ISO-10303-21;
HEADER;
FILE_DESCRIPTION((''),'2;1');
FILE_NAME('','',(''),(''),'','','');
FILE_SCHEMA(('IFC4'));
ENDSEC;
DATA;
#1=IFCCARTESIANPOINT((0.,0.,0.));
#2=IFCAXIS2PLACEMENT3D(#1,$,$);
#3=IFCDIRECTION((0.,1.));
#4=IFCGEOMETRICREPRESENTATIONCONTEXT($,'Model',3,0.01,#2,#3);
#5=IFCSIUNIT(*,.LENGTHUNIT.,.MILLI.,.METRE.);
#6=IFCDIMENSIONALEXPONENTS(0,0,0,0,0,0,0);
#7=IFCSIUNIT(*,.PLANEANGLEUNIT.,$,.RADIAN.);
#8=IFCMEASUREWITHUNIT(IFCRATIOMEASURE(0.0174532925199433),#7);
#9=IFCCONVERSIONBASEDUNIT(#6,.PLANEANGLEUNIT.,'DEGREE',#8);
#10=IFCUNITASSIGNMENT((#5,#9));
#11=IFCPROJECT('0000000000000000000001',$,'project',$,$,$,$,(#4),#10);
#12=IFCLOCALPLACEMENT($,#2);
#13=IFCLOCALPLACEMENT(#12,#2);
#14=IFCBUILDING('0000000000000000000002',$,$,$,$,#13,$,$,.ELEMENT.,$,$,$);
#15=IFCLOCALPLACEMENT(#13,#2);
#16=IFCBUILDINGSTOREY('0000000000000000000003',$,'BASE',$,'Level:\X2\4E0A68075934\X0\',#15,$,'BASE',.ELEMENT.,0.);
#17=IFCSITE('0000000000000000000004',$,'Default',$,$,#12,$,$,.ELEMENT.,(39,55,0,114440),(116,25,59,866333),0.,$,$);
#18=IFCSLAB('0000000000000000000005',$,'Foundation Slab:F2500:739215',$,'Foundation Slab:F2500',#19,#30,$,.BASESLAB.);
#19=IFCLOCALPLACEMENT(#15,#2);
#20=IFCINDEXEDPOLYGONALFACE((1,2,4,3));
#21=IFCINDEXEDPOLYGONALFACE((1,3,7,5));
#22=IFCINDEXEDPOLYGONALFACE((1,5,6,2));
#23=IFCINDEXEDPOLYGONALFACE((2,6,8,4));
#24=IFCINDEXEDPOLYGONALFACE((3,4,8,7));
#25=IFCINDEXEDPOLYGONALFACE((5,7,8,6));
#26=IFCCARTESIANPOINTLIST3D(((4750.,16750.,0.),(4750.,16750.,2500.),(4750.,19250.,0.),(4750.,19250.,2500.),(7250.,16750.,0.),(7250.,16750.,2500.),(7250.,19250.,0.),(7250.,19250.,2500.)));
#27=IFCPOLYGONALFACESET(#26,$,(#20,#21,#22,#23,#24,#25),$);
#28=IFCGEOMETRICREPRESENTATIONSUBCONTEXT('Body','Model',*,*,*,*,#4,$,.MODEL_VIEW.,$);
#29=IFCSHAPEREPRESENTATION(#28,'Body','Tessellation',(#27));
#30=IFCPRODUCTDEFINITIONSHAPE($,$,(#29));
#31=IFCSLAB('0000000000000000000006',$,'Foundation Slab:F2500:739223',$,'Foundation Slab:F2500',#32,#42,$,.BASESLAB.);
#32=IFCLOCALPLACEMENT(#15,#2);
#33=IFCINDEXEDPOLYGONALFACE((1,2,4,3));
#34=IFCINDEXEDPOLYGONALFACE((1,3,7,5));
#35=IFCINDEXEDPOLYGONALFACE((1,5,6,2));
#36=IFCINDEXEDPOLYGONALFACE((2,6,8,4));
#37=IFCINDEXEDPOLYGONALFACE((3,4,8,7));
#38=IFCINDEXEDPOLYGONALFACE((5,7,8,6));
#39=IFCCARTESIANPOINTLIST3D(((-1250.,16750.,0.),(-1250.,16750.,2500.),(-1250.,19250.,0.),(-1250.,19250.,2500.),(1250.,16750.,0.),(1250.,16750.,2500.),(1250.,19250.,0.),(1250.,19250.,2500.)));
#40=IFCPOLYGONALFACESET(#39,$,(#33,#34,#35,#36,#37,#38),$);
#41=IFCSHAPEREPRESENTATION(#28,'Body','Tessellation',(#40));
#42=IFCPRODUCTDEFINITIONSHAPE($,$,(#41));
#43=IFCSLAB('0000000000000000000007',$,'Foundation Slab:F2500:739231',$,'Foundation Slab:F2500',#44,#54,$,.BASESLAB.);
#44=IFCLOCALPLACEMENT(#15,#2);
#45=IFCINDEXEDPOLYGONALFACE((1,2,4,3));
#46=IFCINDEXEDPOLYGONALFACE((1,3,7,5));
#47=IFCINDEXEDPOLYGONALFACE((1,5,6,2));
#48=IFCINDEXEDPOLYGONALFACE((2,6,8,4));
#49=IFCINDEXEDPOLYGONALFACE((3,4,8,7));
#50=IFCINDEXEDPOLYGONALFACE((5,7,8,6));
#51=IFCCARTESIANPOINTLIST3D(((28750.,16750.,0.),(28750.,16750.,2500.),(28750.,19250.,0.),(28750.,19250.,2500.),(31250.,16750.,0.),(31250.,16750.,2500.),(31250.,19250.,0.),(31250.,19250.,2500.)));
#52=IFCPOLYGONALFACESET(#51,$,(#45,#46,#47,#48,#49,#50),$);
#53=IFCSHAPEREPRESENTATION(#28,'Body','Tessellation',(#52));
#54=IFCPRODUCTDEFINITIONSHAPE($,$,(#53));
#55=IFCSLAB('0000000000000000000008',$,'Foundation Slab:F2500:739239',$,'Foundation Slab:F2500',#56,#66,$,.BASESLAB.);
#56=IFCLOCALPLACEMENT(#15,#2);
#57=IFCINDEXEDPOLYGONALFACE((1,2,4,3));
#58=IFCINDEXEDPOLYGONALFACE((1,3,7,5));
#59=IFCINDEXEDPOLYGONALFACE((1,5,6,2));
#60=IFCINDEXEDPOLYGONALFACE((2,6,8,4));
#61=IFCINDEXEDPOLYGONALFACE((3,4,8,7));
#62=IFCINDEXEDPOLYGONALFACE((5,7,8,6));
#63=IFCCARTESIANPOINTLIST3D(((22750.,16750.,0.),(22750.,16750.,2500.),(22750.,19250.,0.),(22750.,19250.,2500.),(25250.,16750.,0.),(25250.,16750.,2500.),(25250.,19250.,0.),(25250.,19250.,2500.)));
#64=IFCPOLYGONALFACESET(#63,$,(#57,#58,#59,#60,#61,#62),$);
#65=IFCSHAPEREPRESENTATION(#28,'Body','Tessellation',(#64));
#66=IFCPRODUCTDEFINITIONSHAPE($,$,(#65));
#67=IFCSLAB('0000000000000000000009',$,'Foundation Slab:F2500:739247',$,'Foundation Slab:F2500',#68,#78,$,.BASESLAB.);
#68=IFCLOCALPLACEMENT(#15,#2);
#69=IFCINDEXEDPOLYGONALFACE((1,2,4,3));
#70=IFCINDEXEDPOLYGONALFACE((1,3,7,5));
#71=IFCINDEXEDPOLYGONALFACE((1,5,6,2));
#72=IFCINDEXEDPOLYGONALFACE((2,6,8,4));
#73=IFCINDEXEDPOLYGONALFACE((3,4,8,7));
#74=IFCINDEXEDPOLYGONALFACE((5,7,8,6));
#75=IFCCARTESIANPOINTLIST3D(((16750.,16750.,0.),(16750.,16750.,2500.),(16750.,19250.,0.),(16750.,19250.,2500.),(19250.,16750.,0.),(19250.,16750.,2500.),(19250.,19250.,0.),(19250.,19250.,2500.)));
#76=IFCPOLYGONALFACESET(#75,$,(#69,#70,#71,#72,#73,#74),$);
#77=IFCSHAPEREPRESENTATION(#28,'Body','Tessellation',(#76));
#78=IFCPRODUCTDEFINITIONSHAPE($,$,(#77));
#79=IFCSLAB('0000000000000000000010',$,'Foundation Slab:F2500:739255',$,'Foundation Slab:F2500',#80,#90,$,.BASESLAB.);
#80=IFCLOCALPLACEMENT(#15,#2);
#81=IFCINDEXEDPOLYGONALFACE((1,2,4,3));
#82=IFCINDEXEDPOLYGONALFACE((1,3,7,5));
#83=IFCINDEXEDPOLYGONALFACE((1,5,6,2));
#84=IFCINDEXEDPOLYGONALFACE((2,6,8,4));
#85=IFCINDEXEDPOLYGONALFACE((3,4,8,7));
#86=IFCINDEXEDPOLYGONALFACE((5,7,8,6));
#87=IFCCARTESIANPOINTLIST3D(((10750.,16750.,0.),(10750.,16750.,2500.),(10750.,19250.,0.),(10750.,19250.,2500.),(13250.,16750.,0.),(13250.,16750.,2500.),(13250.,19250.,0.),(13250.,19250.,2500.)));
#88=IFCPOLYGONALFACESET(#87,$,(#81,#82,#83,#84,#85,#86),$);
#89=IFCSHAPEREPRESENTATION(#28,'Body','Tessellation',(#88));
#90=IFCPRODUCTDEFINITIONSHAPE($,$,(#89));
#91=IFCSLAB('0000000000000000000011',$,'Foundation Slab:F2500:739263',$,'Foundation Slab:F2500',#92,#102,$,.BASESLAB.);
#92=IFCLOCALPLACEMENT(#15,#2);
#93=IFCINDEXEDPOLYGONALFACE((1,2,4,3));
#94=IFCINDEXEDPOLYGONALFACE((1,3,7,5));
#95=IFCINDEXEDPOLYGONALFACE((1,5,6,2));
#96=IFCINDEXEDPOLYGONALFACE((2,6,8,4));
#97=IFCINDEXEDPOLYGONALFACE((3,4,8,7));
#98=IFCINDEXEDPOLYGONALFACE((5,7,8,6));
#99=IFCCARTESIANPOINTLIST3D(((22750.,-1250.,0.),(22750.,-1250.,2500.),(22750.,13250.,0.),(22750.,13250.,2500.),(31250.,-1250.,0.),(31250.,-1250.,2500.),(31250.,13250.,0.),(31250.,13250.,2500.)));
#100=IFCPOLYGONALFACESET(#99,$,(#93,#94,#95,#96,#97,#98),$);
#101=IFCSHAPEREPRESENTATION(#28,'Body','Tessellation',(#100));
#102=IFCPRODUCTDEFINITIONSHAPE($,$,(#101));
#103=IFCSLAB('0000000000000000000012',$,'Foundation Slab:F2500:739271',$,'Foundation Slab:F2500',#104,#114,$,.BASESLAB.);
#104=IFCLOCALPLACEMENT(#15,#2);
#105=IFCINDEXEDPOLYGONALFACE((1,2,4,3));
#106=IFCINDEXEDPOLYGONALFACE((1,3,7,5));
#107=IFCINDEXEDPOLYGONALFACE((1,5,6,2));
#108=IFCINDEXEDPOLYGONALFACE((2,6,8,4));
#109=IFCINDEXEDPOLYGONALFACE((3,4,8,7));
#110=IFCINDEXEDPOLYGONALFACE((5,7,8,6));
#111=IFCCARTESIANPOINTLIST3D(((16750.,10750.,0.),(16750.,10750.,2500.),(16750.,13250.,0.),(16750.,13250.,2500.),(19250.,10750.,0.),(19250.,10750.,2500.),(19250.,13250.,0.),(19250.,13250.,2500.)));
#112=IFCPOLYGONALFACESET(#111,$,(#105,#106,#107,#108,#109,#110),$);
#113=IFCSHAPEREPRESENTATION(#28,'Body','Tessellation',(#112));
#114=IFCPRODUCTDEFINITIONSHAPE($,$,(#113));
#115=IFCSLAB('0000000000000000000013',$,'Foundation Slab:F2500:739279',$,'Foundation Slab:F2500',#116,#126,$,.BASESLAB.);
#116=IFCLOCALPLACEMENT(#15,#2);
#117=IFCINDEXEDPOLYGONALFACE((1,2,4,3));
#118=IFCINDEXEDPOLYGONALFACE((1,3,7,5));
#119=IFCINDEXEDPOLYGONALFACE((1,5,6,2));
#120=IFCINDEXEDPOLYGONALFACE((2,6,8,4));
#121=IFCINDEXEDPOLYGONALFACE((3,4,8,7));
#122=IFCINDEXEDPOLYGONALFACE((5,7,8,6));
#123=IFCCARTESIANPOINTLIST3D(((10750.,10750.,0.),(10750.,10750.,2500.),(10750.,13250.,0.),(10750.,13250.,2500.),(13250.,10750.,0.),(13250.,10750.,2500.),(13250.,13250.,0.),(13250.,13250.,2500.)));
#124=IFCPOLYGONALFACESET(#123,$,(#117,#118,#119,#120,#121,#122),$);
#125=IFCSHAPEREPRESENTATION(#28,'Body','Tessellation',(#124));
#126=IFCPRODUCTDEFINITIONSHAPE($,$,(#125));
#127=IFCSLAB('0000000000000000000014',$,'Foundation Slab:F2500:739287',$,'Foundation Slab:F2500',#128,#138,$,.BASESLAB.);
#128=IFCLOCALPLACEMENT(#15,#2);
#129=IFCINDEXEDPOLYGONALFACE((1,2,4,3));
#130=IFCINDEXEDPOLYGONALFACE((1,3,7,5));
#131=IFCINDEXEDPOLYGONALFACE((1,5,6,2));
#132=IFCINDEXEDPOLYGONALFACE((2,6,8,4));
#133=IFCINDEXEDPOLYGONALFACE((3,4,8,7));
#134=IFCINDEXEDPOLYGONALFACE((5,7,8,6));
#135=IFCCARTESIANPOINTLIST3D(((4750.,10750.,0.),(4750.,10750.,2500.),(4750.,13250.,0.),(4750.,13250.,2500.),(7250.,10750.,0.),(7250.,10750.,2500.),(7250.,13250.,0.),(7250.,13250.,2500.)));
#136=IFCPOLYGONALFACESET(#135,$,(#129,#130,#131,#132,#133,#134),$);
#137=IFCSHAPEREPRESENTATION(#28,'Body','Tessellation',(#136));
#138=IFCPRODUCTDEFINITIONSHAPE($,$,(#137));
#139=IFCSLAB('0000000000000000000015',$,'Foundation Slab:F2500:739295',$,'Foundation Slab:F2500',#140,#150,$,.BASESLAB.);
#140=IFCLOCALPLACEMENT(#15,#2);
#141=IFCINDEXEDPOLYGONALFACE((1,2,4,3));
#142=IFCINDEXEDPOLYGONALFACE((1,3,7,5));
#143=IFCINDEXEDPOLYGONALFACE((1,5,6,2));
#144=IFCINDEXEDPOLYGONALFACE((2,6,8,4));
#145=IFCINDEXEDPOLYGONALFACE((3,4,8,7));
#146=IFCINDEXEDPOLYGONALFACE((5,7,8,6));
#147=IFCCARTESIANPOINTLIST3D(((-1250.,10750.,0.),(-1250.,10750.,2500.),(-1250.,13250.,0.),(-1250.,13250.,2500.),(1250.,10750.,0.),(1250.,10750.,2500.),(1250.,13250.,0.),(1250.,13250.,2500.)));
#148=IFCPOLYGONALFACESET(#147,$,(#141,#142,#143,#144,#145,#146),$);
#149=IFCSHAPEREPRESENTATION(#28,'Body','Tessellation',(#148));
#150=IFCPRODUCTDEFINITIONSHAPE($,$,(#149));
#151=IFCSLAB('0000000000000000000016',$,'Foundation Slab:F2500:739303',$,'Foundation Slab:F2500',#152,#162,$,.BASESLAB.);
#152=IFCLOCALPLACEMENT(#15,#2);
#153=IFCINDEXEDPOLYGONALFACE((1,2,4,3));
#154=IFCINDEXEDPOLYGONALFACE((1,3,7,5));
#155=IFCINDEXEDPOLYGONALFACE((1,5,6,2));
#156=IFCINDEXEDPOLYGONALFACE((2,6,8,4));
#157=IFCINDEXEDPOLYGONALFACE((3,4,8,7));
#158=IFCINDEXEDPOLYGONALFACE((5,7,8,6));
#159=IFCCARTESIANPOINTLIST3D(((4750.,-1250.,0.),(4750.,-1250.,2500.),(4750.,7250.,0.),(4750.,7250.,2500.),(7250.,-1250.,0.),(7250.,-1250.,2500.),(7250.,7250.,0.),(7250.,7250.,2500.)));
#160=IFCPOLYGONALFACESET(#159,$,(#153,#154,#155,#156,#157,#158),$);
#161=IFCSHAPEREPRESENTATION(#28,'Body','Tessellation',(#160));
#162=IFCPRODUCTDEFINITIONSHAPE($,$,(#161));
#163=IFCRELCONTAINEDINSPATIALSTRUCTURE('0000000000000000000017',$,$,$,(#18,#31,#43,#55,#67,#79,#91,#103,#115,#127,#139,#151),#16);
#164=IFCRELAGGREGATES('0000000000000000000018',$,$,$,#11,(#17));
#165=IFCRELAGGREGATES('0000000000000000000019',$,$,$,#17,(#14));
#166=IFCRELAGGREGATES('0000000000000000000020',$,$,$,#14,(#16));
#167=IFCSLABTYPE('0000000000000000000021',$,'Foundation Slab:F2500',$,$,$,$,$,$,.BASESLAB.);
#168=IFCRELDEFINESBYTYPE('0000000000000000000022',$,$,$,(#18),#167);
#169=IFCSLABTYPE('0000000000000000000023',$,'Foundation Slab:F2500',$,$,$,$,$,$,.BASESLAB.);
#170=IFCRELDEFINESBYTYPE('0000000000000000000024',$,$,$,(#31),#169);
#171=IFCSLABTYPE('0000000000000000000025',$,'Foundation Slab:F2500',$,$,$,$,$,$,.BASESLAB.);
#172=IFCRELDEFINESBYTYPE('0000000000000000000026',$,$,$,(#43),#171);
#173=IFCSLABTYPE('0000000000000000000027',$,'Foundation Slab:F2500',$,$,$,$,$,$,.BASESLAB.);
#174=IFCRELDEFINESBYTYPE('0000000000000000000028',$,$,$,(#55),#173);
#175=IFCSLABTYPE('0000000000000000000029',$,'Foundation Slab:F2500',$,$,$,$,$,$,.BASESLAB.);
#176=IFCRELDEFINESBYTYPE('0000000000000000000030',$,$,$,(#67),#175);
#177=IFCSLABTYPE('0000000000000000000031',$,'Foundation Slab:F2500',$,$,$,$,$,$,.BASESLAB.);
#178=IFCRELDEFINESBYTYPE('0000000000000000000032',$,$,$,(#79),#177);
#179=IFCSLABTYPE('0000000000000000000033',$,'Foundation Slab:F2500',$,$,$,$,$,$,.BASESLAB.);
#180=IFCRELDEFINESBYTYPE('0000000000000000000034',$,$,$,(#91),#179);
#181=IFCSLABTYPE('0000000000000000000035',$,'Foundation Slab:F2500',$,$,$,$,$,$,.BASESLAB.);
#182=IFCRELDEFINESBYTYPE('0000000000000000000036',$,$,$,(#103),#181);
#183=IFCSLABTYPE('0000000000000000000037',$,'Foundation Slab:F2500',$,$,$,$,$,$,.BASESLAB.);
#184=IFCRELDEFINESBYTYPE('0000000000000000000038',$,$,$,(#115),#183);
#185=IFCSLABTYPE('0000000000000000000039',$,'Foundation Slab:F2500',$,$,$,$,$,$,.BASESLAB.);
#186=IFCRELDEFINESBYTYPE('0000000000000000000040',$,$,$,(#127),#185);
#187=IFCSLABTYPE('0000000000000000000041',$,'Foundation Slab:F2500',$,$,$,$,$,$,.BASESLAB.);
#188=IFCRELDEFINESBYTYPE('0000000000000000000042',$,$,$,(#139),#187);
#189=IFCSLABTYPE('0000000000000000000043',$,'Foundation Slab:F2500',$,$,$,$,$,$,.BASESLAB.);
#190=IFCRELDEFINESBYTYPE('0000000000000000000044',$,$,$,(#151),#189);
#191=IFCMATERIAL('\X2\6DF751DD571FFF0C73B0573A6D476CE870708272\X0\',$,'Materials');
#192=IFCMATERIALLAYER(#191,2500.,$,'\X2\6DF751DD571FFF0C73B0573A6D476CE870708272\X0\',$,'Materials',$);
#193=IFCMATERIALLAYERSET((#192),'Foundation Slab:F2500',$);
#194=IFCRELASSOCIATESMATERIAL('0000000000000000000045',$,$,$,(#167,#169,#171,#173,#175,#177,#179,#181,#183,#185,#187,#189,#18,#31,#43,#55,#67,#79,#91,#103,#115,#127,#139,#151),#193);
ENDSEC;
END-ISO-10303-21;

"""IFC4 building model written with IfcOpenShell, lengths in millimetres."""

from ifc_helpers import new_model, entity, si_unit, converted_unit, direction, frame, origin, origin_2d_with_axis, place, context, subcontext, project, spatial, rectangle, extrude, material, layer, layer_set, layer_usage, type_object, element, save


model = new_model("IFC4")

# Units and contexts
model_context = context("Model", 3, precision=0.01, world=origin(), true_north=direction((0.0, 1.0)))
body_context = subcontext(model_context, "Body", "Model", "MODEL_VIEW")
ifc_project = project(units=[si_unit("LENGTHUNIT", "METRE", prefix="MILLI"), converted_unit("PLANEANGLEUNIT", "DEGREE", entity("IfcRatioMeasure", 0.0174532925199433), si_unit("PLANEANGLEUNIT", "RADIAN"), dimensions=[0, 0, 0, 0, 0, 0, 0])], contexts=[model_context])

# Site, building, storey
site_placement = place(None, origin())
site = spatial("IfcSite", under=ifc_project, at=site_placement, Name="Default", CompositionType="ELEMENT", RefLatitude=(39, 55, 0, 114440), RefLongitude=(116, 25, 59, 866333), RefElevation=0.0)
building_placement = place(site_placement, origin())
building = spatial("IfcBuilding", under=site, at=building_placement, CompositionType="ELEMENT")
storey_placement = place(building_placement, origin())
storey = spatial("IfcBuildingStorey", under=building, at=storey_placement, Name="BASE", ObjectType="Level:上标头", LongName="BASE", CompositionType="ELEMENT", Elevation=0.0)

# Slabs
ifc_material = material(Name="混凝土，现场浇注灰色", Category="Materials")
ifc_layer = layer(ifc_material, 2500.0, Name="混凝土，现场浇注灰色", Category="Materials")
ifc_layer_set = layer_set([ifc_layer], Name="Foundation Slab:F2500")
ifc_layer_usage_1 = layer_usage(ifc_layer_set, "AXIS3", "POSITIVE", 0.0)
slab_type_1 = type_object("IfcSlabType", Name="Foundation Slab:F2500", PredefinedType="BASESLAB", material=ifc_layer_set)
slab_1_placement = place(storey_placement, origin())
element("IfcSlab", 1, at=slab_1_placement, inside=storey, type_object=slab_type_1, material=ifc_layer_usage_1, Name="Foundation Slab:F2500:739215", ObjectType="Foundation Slab:F2500", PredefinedType="BASESLAB", context=body_context, shape_type="SweptSolid", body=[
    extrude(rectangle(XDim=2500.0, YDim=2500.0, at=origin_2d_with_axis()), frame((6000.0, 18000.0, 2500.0), z_axis=(0.0, 0.0, -1.0), x_axis=(0.0, 1.0, 0.0)), (0.0, 0.0, 1.0), 2500.0),
])
ifc_layer_usage_2 = layer_usage(ifc_layer_set, "AXIS3", "POSITIVE", 0.0)
slab_type_2 = type_object("IfcSlabType", Name="Foundation Slab:F2500", PredefinedType="BASESLAB", material=ifc_layer_set)
slab_2_placement = place(storey_placement, origin())
element("IfcSlab", 2, at=slab_2_placement, inside=storey, type_object=slab_type_2, material=ifc_layer_usage_2, Name="Foundation Slab:F2500:739223", ObjectType="Foundation Slab:F2500", PredefinedType="BASESLAB", context=body_context, shape_type="SweptSolid", body=[
    extrude(rectangle(XDim=2500.0, YDim=2500.0, at=origin_2d_with_axis()), frame((0.0, 18000.0, 2500.0), z_axis=(0.0, 0.0, -1.0), x_axis=(0.0, 1.0, 0.0)), (0.0, 0.0, 1.0), 2500.0),
])
ifc_layer_usage_3 = layer_usage(ifc_layer_set, "AXIS3", "POSITIVE", 0.0)
slab_type_3 = type_object("IfcSlabType", Name="Foundation Slab:F2500", PredefinedType="BASESLAB", material=ifc_layer_set)
slab_3_placement = place(storey_placement, origin())
element("IfcSlab", 3, at=slab_3_placement, inside=storey, type_object=slab_type_3, material=ifc_layer_usage_3, Name="Foundation Slab:F2500:739231", ObjectType="Foundation Slab:F2500", PredefinedType="BASESLAB", context=body_context, shape_type="SweptSolid", body=[
    extrude(rectangle(XDim=2500.0, YDim=2500.0, at=origin_2d_with_axis()), frame((30000.0, 18000.0, 2500.0), z_axis=(0.0, 0.0, -1.0), x_axis=(0.0, 1.0, 0.0)), (0.0, 0.0, 1.0), 2500.0),
])
ifc_layer_usage_4 = layer_usage(ifc_layer_set, "AXIS3", "POSITIVE", 0.0)
slab_type_4 = type_object("IfcSlabType", Name="Foundation Slab:F2500", PredefinedType="BASESLAB", material=ifc_layer_set)
slab_4_placement = place(storey_placement, origin())
element("IfcSlab", 4, at=slab_4_placement, inside=storey, type_object=slab_type_4, material=ifc_layer_usage_4, Name="Foundation Slab:F2500:739239", ObjectType="Foundation Slab:F2500", PredefinedType="BASESLAB", context=body_context, shape_type="SweptSolid", body=[
    extrude(rectangle(XDim=2500.0, YDim=2500.0, at=origin_2d_with_axis()), frame((24000.0, 18000.0, 2500.0), z_axis=(0.0, 0.0, -1.0), x_axis=(0.0, 1.0, 0.0)), (0.0, 0.0, 1.0), 2500.0),
])
ifc_layer_usage_5 = layer_usage(ifc_layer_set, "AXIS3", "POSITIVE", 0.0)
slab_type_5 = type_object("IfcSlabType", Name="Foundation Slab:F2500", PredefinedType="BASESLAB", material=ifc_layer_set)
slab_5_placement = place(storey_placement, origin())
element("IfcSlab", 5, at=slab_5_placement, inside=storey, type_object=slab_type_5, material=ifc_layer_usage_5, Name="Foundation Slab:F2500:739247", ObjectType="Foundation Slab:F2500", PredefinedType="BASESLAB", context=body_context, shape_type="SweptSolid", body=[
    extrude(rectangle(XDim=2500.0, YDim=2500.0, at=origin_2d_with_axis()), frame((18000.0, 18000.0, 2500.0), z_axis=(0.0, 0.0, -1.0), x_axis=(0.0, 1.0, 0.0)), (0.0, 0.0, 1.0), 2500.0),
])
ifc_layer_usage_6 = layer_usage(ifc_layer_set, "AXIS3", "POSITIVE", 0.0)
slab_type_6 = type_object("IfcSlabType", Name="Foundation Slab:F2500", PredefinedType="BASESLAB", material=ifc_layer_set)
slab_6_placement = place(storey_placement, origin())
element("IfcSlab", 6, at=slab_6_placement, inside=storey, type_object=slab_type_6, material=ifc_layer_usage_6, Name="Foundation Slab:F2500:739255", ObjectType="Foundation Slab:F2500", PredefinedType="BASESLAB", context=body_context, shape_type="SweptSolid", body=[
    extrude(rectangle(XDim=2500.0, YDim=2500.0, at=origin_2d_with_axis()), frame((12000.0, 18000.0, 2500.0), z_axis=(0.0, 0.0, -1.0), x_axis=(0.0, 1.0, 0.0)), (0.0, 0.0, 1.0), 2500.0),
])
ifc_layer_usage_7 = layer_usage(ifc_layer_set, "AXIS3", "POSITIVE", 0.0)
slab_type_7 = type_object("IfcSlabType", Name="Foundation Slab:F2500", PredefinedType="BASESLAB", material=ifc_layer_set)
slab_7_placement = place(storey_placement, origin())
element("IfcSlab", 7, at=slab_7_placement, inside=storey, type_object=slab_type_7, material=ifc_layer_usage_7, Name="Foundation Slab:F2500:739263", ObjectType="Foundation Slab:F2500", PredefinedType="BASESLAB", context=body_context, shape_type="SweptSolid", body=[
    extrude(rectangle(XDim=14500.0, YDim=8500.0, at=origin_2d_with_axis()), frame((27000.0, 6000.0, 2500.0), z_axis=(0.0, 0.0, -1.0), x_axis=(0.0, 1.0, 0.0)), (0.0, 0.0, 1.0), 2500.0),
])
ifc_layer_usage_8 = layer_usage(ifc_layer_set, "AXIS3", "POSITIVE", 0.0)
slab_type_8 = type_object("IfcSlabType", Name="Foundation Slab:F2500", PredefinedType="BASESLAB", material=ifc_layer_set)
slab_8_placement = place(storey_placement, origin())
element("IfcSlab", 8, at=slab_8_placement, inside=storey, type_object=slab_type_8, material=ifc_layer_usage_8, Name="Foundation Slab:F2500:739271", ObjectType="Foundation Slab:F2500", PredefinedType="BASESLAB", context=body_context, shape_type="SweptSolid", body=[
    extrude(rectangle(XDim=2500.0, YDim=2500.0, at=origin_2d_with_axis()), frame((18000.0, 12000.0, 2500.0), z_axis=(0.0, 0.0, -1.0), x_axis=(0.0, 1.0, 0.0)), (0.0, 0.0, 1.0), 2500.0),
])
ifc_layer_usage_9 = layer_usage(ifc_layer_set, "AXIS3", "POSITIVE", 0.0)
slab_type_9 = type_object("IfcSlabType", Name="Foundation Slab:F2500", PredefinedType="BASESLAB", material=ifc_layer_set)
slab_9_placement = place(storey_placement, origin())
element("IfcSlab", 9, at=slab_9_placement, inside=storey, type_object=slab_type_9, material=ifc_layer_usage_9, Name="Foundation Slab:F2500:739279", ObjectType="Foundation Slab:F2500", PredefinedType="BASESLAB", context=body_context, shape_type="SweptSolid", body=[
    extrude(rectangle(XDim=2500.0, YDim=2500.0, at=origin_2d_with_axis()), frame((12000.0, 12000.0, 2500.0), z_axis=(0.0, 0.0, -1.0), x_axis=(0.0, 1.0, 0.0)), (0.0, 0.0, 1.0), 2500.0),
])
ifc_layer_usage_10 = layer_usage(ifc_layer_set, "AXIS3", "POSITIVE", 0.0)
slab_type_10 = type_object("IfcSlabType", Name="Foundation Slab:F2500", PredefinedType="BASESLAB", material=ifc_layer_set)
slab_10_placement = place(storey_placement, origin())
element("IfcSlab", 10, at=slab_10_placement, inside=storey, type_object=slab_type_10, material=ifc_layer_usage_10, Name="Foundation Slab:F2500:739287", ObjectType="Foundation Slab:F2500", PredefinedType="BASESLAB", context=body_context, shape_type="SweptSolid", body=[
    extrude(rectangle(XDim=2500.0, YDim=2500.0, at=origin_2d_with_axis()), frame((6000.0, 12000.0, 2500.0), z_axis=(0.0, 0.0, -1.0), x_axis=(0.0, 1.0, 0.0)), (0.0, 0.0, 1.0), 2500.0),
])
ifc_layer_usage_11 = layer_usage(ifc_layer_set, "AXIS3", "POSITIVE", 0.0)
slab_type_11 = type_object("IfcSlabType", Name="Foundation Slab:F2500", PredefinedType="BASESLAB", material=ifc_layer_set)
slab_11_placement = place(storey_placement, origin())
element("IfcSlab", 11, at=slab_11_placement, inside=storey, type_object=slab_type_11, material=ifc_layer_usage_11, Name="Foundation Slab:F2500:739295", ObjectType="Foundation Slab:F2500", PredefinedType="BASESLAB", context=body_context, shape_type="SweptSolid", body=[
    extrude(rectangle(XDim=2500.0, YDim=2500.0, at=origin_2d_with_axis()), frame((0.0, 12000.0, 2500.0), z_axis=(0.0, 0.0, -1.0), x_axis=(0.0, 1.0, 0.0)), (0.0, 0.0, 1.0), 2500.0),
])
ifc_layer_usage_12 = layer_usage(ifc_layer_set, "AXIS3", "POSITIVE", 0.0)
slab_type_12 = type_object("IfcSlabType", Name="Foundation Slab:F2500", PredefinedType="BASESLAB", material=ifc_layer_set)
slab_12_placement = place(storey_placement, origin())
element("IfcSlab", 12, at=slab_12_placement, inside=storey, type_object=slab_type_12, material=ifc_layer_usage_12, Name="Foundation Slab:F2500:739303", ObjectType="Foundation Slab:F2500", PredefinedType="BASESLAB", context=body_context, shape_type="SweptSolid", body=[
    extrude(rectangle(XDim=8500.0, YDim=2500.0, at=origin_2d_with_axis()), frame((6000.0, 3000.0, 2500.0), z_axis=(0.0, 0.0, -1.0), x_axis=(0.0, 1.0, 0.0)), (0.0, 0.0, 1.0), 2500.0),
])

save(model, "model.ifc")
